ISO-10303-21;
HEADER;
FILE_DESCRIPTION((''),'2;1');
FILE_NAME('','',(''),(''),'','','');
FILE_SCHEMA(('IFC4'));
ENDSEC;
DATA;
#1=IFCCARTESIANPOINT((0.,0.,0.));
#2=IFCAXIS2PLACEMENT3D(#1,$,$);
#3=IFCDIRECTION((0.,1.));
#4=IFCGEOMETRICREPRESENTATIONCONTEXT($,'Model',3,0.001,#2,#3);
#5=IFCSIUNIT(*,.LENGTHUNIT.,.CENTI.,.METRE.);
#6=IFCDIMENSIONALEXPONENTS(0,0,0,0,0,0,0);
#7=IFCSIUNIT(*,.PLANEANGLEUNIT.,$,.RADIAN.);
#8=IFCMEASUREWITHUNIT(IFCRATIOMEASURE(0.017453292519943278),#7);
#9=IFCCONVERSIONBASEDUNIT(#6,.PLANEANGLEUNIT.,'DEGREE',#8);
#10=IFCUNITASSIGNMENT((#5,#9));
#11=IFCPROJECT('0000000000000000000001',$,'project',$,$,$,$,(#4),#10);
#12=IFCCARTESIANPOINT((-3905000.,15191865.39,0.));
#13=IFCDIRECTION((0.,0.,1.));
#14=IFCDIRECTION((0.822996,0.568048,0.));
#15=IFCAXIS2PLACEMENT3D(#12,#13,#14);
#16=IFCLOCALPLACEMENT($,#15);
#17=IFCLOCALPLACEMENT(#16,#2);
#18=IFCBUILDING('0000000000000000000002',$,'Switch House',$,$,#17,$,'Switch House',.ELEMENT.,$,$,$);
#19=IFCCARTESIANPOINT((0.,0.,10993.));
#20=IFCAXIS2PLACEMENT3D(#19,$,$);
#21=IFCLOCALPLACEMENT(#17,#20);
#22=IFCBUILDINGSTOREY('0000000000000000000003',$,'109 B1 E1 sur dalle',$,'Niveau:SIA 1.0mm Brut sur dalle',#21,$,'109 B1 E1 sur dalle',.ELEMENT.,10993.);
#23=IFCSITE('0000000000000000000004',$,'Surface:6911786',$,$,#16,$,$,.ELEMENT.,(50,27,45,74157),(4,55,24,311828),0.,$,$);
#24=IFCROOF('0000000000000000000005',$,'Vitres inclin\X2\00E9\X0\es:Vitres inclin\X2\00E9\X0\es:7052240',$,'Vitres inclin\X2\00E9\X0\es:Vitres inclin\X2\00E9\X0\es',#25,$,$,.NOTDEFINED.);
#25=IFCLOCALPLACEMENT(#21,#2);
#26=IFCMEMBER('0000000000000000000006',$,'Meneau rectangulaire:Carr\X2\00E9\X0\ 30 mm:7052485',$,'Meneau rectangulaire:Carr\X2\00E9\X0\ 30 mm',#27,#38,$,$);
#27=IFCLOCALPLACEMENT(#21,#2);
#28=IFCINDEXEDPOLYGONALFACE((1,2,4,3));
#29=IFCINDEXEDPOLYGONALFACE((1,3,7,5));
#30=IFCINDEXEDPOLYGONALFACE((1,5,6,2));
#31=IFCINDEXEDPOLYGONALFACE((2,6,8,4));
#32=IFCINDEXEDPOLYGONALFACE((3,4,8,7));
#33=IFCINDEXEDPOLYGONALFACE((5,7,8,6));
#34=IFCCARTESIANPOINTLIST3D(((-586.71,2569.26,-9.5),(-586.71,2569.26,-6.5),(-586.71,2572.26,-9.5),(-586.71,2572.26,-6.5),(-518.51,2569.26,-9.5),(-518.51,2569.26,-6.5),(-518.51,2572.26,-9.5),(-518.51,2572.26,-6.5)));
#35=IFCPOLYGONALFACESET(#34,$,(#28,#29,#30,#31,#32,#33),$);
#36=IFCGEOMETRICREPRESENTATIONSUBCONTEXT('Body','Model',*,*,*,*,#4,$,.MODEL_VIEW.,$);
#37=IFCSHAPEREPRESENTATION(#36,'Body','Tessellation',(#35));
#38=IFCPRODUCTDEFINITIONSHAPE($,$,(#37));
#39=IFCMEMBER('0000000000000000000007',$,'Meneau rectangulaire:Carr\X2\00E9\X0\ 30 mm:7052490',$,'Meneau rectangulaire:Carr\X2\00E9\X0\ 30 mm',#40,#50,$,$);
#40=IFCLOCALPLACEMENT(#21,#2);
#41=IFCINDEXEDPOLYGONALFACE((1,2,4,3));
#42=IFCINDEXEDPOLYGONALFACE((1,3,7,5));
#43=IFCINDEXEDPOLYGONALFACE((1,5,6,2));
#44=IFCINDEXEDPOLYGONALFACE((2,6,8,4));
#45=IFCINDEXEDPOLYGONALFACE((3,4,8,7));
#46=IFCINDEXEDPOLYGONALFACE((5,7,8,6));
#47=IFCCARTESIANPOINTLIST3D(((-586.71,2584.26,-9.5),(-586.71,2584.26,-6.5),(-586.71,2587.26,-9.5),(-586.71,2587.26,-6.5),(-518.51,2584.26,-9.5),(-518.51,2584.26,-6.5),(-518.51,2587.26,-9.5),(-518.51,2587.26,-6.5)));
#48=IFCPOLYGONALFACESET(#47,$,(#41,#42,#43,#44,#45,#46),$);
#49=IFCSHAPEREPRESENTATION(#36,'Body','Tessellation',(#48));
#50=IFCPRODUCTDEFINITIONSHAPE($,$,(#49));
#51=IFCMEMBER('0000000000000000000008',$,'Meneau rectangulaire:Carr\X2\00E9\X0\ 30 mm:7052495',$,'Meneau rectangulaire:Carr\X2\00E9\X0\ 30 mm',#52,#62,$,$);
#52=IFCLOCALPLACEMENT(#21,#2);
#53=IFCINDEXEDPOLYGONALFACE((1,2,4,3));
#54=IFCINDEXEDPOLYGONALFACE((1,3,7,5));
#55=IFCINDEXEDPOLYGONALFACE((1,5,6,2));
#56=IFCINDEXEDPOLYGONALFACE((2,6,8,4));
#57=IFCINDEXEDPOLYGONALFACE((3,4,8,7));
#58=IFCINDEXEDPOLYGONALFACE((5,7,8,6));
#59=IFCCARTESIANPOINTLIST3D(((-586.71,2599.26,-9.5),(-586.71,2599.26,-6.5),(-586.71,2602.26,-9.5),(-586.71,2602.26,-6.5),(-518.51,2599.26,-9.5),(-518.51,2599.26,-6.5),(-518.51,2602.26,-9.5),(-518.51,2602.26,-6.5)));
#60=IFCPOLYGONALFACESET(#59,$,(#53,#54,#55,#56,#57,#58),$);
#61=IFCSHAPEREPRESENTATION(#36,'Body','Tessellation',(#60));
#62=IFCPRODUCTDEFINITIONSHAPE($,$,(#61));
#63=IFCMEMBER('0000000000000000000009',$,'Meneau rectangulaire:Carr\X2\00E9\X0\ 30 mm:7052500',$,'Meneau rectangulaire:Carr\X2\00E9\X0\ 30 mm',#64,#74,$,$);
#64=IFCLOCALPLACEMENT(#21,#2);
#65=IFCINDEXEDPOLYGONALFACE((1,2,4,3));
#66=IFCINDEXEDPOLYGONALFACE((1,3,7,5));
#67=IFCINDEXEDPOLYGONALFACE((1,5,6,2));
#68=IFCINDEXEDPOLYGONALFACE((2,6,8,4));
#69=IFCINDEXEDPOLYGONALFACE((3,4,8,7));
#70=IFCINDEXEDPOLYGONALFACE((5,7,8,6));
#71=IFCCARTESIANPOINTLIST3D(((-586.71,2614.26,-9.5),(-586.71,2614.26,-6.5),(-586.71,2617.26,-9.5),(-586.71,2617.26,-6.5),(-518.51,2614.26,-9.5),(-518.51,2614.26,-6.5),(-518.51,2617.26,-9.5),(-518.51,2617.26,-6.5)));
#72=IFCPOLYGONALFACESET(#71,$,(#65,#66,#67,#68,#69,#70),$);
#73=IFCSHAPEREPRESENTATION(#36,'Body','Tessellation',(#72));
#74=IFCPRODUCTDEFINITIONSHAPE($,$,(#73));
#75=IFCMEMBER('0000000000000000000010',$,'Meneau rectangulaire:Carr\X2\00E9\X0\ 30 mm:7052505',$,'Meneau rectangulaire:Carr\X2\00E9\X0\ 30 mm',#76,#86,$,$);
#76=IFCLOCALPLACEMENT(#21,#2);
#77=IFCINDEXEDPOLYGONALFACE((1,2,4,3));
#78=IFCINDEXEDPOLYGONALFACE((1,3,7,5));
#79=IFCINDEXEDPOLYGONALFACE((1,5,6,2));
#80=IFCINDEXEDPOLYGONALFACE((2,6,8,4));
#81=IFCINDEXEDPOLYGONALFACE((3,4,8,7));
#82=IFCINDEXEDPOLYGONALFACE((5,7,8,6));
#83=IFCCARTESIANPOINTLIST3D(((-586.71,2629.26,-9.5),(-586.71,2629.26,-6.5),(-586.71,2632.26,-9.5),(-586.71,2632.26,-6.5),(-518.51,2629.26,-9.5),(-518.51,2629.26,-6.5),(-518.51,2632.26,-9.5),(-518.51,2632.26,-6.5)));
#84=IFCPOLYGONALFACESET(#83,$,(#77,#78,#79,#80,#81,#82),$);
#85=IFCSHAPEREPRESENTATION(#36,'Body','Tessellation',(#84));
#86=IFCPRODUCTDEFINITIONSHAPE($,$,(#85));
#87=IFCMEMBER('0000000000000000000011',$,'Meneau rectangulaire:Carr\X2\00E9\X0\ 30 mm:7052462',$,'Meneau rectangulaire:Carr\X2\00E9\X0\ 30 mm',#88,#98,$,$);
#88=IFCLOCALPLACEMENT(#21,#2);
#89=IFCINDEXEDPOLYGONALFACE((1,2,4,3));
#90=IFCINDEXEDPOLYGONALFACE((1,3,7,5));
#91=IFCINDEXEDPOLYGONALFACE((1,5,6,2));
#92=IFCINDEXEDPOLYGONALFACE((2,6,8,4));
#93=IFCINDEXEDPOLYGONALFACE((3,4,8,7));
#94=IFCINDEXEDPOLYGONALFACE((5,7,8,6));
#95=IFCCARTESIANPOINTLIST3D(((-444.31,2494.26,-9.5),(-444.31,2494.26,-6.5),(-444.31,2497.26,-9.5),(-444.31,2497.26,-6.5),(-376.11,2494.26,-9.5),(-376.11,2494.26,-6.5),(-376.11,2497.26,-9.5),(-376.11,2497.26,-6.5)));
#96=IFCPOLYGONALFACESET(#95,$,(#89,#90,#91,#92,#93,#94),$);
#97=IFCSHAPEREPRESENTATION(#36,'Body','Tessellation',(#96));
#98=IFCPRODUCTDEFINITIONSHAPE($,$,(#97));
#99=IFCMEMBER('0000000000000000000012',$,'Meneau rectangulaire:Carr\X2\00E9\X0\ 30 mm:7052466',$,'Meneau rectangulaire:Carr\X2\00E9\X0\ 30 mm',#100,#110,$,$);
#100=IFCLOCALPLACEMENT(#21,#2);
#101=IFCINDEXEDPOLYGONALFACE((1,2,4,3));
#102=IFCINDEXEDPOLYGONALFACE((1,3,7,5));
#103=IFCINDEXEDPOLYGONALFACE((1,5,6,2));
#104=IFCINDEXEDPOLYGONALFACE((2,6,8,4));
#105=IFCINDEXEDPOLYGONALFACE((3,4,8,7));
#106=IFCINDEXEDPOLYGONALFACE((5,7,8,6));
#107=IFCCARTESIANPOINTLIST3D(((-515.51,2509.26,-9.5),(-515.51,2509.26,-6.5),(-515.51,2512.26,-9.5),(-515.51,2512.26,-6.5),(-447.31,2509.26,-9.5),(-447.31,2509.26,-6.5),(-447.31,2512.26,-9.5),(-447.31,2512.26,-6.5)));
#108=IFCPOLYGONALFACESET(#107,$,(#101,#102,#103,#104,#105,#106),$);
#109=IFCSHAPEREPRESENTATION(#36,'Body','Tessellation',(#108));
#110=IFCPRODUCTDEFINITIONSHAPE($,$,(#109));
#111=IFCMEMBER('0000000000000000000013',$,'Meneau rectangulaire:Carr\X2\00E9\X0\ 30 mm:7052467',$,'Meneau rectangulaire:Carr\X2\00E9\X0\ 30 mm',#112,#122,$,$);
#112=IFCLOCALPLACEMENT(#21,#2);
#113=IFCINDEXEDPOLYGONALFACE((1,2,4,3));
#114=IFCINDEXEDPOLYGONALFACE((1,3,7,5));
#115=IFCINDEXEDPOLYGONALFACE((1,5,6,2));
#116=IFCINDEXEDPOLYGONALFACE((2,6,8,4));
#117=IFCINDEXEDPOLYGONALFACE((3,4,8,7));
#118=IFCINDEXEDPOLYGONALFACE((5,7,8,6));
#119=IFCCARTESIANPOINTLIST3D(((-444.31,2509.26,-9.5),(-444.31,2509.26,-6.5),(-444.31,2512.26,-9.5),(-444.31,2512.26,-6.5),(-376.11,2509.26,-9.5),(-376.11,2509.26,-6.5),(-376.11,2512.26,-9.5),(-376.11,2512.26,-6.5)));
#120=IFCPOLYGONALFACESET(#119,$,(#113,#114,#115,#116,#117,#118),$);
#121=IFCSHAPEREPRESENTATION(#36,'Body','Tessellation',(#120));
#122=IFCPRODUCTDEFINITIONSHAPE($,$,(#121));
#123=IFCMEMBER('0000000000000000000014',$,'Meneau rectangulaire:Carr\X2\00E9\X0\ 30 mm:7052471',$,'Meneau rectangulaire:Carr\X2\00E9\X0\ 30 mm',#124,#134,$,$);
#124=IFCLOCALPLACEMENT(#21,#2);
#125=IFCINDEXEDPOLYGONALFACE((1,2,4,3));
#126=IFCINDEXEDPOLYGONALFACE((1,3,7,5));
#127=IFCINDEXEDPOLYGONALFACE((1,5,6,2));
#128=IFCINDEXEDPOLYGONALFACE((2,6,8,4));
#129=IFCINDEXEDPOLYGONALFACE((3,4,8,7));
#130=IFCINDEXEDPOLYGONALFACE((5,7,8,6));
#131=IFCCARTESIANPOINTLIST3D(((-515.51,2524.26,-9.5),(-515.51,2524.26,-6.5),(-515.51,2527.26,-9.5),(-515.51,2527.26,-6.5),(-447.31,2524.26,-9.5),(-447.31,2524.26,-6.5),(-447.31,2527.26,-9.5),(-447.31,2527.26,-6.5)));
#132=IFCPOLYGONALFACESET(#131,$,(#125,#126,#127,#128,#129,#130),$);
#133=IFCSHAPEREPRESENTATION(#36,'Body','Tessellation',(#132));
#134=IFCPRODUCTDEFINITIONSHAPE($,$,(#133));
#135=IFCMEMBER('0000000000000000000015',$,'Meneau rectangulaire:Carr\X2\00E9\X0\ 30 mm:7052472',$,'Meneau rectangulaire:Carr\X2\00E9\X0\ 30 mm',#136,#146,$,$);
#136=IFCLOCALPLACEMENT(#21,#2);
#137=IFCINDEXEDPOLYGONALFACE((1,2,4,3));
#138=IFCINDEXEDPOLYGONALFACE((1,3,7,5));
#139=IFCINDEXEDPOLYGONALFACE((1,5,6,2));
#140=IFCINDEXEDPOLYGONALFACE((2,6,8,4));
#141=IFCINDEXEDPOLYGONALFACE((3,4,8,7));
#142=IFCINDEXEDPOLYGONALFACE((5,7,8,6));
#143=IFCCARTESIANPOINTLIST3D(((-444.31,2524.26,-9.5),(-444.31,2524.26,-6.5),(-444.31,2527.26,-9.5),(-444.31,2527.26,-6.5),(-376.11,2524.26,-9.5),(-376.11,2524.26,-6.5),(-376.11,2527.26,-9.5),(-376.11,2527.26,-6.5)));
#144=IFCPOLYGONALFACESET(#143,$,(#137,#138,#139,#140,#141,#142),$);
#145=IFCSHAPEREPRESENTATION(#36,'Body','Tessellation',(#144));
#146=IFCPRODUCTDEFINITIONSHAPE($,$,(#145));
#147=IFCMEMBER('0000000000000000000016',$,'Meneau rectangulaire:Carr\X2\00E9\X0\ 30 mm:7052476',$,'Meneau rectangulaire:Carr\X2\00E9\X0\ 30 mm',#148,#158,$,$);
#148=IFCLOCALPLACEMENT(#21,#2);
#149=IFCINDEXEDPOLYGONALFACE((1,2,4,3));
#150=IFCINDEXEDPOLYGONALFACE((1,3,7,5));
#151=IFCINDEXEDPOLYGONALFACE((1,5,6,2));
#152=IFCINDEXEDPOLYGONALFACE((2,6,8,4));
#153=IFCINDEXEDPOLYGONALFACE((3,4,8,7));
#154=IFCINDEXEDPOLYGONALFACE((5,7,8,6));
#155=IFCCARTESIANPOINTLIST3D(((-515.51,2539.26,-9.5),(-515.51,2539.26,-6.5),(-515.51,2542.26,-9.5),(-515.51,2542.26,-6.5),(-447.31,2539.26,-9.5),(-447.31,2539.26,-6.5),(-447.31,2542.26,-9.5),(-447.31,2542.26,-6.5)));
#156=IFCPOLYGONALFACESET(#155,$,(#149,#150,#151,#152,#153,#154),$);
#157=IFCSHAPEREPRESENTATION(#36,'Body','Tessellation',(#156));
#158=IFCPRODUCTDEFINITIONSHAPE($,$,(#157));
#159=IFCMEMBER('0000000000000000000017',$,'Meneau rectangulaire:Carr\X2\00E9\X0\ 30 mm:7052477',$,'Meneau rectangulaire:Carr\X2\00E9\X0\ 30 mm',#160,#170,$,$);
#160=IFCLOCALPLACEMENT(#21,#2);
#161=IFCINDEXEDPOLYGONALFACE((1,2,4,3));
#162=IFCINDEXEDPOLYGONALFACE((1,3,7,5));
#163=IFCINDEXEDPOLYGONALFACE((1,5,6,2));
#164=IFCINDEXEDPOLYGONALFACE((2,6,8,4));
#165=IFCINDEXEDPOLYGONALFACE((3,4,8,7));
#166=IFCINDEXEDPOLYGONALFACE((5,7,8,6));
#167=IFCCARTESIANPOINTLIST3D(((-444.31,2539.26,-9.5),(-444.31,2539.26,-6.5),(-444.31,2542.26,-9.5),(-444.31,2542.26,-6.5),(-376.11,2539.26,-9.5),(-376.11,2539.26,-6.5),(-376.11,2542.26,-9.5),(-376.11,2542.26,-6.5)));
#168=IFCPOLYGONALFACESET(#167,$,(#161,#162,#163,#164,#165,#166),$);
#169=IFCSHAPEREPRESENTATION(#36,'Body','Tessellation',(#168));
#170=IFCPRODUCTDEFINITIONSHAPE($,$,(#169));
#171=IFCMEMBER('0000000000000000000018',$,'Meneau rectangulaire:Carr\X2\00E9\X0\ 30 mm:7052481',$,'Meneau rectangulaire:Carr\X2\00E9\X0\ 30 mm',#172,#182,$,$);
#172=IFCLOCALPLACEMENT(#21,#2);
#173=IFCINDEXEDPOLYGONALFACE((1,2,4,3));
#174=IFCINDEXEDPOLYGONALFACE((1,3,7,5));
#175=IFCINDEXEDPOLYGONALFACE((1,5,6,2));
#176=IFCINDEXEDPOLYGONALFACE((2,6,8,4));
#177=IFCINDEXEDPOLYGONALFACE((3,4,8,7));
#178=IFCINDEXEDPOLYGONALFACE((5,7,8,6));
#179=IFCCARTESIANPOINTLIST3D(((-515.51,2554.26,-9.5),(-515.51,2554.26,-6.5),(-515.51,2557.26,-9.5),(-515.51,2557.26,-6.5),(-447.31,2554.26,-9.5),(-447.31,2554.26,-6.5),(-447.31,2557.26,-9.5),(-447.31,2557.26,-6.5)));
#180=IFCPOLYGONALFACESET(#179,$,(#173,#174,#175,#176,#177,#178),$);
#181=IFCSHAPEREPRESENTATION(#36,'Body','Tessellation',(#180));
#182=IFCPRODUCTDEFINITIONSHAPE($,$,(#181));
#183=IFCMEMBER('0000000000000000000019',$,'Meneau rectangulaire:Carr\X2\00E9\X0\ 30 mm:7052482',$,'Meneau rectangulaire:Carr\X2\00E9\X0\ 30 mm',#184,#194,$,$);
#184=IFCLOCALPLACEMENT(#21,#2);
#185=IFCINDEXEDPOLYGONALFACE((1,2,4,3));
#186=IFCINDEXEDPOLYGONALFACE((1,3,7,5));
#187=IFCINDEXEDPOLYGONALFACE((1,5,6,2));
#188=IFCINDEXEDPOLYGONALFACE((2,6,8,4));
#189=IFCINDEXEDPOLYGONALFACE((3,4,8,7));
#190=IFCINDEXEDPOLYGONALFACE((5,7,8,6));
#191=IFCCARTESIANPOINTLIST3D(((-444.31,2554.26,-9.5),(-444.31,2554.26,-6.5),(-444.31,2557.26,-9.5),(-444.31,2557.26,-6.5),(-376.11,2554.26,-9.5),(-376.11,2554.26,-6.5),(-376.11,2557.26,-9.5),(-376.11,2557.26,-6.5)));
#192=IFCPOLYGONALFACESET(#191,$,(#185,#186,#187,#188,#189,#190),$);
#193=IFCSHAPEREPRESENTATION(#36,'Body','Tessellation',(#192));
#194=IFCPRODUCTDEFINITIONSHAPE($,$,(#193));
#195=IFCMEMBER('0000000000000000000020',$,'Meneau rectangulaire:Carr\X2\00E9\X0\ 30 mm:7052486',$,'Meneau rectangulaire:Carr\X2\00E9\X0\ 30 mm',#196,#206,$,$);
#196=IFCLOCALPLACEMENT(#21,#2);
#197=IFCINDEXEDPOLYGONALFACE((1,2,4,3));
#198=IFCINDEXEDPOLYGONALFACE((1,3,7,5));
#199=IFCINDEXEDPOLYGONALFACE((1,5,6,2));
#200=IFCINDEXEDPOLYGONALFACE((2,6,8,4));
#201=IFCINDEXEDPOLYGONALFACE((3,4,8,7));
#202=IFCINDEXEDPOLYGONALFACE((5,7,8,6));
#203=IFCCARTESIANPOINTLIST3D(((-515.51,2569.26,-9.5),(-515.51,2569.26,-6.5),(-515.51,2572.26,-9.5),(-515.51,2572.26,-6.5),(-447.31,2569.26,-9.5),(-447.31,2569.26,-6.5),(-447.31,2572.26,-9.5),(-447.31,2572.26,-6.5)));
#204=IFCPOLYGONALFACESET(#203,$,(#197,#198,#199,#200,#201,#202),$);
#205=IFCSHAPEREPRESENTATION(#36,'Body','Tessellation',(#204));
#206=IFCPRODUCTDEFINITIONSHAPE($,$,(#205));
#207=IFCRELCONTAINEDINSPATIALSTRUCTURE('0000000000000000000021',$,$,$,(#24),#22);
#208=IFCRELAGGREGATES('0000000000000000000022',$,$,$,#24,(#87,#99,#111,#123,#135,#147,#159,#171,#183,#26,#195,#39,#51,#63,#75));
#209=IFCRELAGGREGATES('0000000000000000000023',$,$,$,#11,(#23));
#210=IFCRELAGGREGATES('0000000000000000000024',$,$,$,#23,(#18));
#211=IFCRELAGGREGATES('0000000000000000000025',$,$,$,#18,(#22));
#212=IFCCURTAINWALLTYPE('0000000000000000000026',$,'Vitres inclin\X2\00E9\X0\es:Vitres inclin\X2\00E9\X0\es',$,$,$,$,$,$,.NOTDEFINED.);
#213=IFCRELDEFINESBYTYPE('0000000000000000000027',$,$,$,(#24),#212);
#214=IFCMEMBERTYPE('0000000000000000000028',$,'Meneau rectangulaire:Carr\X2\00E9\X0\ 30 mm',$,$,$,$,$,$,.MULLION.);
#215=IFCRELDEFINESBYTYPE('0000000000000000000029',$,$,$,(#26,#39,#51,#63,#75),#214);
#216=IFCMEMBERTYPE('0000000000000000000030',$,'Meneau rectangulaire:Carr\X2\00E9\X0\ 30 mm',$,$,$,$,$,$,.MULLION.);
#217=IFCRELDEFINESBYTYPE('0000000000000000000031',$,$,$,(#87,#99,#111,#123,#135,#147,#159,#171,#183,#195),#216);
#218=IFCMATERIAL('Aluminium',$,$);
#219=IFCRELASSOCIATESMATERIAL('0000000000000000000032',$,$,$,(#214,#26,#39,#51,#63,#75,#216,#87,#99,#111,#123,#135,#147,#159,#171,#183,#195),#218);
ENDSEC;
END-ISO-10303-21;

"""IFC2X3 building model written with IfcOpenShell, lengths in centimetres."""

from ifc_helpers import new_model, entity, si_unit, converted_unit, direction, frame, origin, origin_2d_with_axis, place, context, subcontext, project, spatial, rectangle, extrude, source, transform, mapped, material, type_object, type_shapes, element, aggregate, save


model = new_model("IFC2X3")

# Units and contexts
model_context = context("Model", 3, precision=0.001, world=origin(), true_north=direction((0.0, 1.0)))
body_context = subcontext(model_context, "Body", "Model", "MODEL_VIEW")
ifc_project = project(units=[si_unit("LENGTHUNIT", "METRE", prefix="CENTI"), converted_unit("PLANEANGLEUNIT", "DEGREE", entity("IfcRatioMeasure", 0.017453292519943278), si_unit("PLANEANGLEUNIT", "RADIAN"), dimensions=[0, 0, 0, 0, 0, 0, 0])], contexts=[model_context])

# Site, building, storey
site_placement = place(None, frame((-3905000.0, 15191865.39, 0.0), z_axis=(0.0, 0.0, 1.0), x_axis=(0.822996, 0.568048, 0.0)))
site = spatial("IfcSite", under=ifc_project, at=site_placement, Name="Surface:6911786", CompositionType="ELEMENT", RefLatitude=(50, 27, 45, 74157), RefLongitude=(4, 55, 24, 311828), RefElevation=0.0)
building_placement = place(site_placement, origin())
building = spatial("IfcBuilding", under=site, at=building_placement, Name="Switch House", LongName="Switch House", CompositionType="ELEMENT")
storey_placement = place(building_placement, frame((0.0, 0.0, 10993.0)))
storey = spatial("IfcBuildingStorey", under=building, at=storey_placement, Name="109 B1 E1 sur dalle", ObjectType="Niveau:SIA 1.0mm Brut sur dalle", LongName="109 B1 E1 sur dalle", CompositionType="ELEMENT", Elevation=10993.0)

# Roof, members
curtain_wall_type = type_object("IfcCurtainWallType", Name="Vitres inclinées:Vitres inclinées", PredefinedType="NOTDEFINED")
roof_placement = place(storey_placement, frame((0.0, 0.0, -10993.0)))
roof = element("IfcRoof", 1, at=roof_placement, inside=storey, type_object=curtain_wall_type, Name="Vitres inclinées:Vitres inclinées:7052240", ObjectType="Vitres inclinées:Vitres inclinées", ShapeType="NOTDEFINED")
ifc_material = material(Name="Aluminium")
member_type_1 = type_object("IfcMemberType", Name="Meneau rectangulaire:Carré 30 mm", PredefinedType="MULLION", material=ifc_material)
shared_shape_1 = source(origin(), body_context, "Body", "SweptSolid", [
    extrude(rectangle(XDim=3.0, YDim=3.0, at=origin_2d_with_axis()), frame((0.0, 0.0, -68.2), z_axis=(0.0, 0.0, 1.0), x_axis=(0.0, -1.0, 0.0)), (0.0, 0.0, 1.0), 68.2),
])
type_shapes(member_type_1, [shared_shape_1])
member_1_placement = place(roof_placement, frame((-586.71, 2570.76, 10985.0), z_axis=(-1.0, 0.0, 0.0), x_axis=(0.0, 1.0, 0.0)))
member_1 = element("IfcMember", 2, at=member_1_placement, type_object=member_type_1, material=ifc_material, Name="Meneau rectangulaire:Carré 30 mm:7052485", ObjectType="Meneau rectangulaire:Carré 30 mm", context=body_context, shape_type="MappedRepresentation", body=[
    mapped(shared_shape_1, transform((0.0, 0.0, 0.0), scale=1.0)),
])
member_2_placement = place(roof_placement, frame((-586.71, 2585.76, 10985.0), z_axis=(-1.0, 0.0, 0.0), x_axis=(0.0, 1.0, 0.0)))
member_2 = element("IfcMember", 3, at=member_2_placement, type_object=member_type_1, material=ifc_material, Name="Meneau rectangulaire:Carré 30 mm:7052490", ObjectType="Meneau rectangulaire:Carré 30 mm", context=body_context, shape_type="MappedRepresentation", body=[
    mapped(shared_shape_1, transform((0.0, 0.0, 0.0), scale=1.0)),
])
member_3_placement = place(roof_placement, frame((-586.71, 2600.76, 10985.0), z_axis=(-1.0, 0.0, 0.0), x_axis=(0.0, 1.0, 0.0)))
member_3 = element("IfcMember", 4, at=member_3_placement, type_object=member_type_1, material=ifc_material, Name="Meneau rectangulaire:Carré 30 mm:7052495", ObjectType="Meneau rectangulaire:Carré 30 mm", context=body_context, shape_type="MappedRepresentation", body=[
    mapped(shared_shape_1, transform((0.0, 0.0, 0.0), scale=1.0)),
])
member_4_placement = place(roof_placement, frame((-586.71, 2615.76, 10985.0), z_axis=(-1.0, 0.0, 0.0), x_axis=(0.0, 1.0, 0.0)))
member_4 = element("IfcMember", 5, at=member_4_placement, type_object=member_type_1, material=ifc_material, Name="Meneau rectangulaire:Carré 30 mm:7052500", ObjectType="Meneau rectangulaire:Carré 30 mm", context=body_context, shape_type="MappedRepresentation", body=[
    mapped(shared_shape_1, transform((0.0, 0.0, 0.0), scale=1.0)),
])
member_5_placement = place(roof_placement, frame((-586.71, 2630.76, 10985.0), z_axis=(-1.0, 0.0, 0.0), x_axis=(0.0, 1.0, 0.0)))
member_5 = element("IfcMember", 6, at=member_5_placement, type_object=member_type_1, material=ifc_material, Name="Meneau rectangulaire:Carré 30 mm:7052505", ObjectType="Meneau rectangulaire:Carré 30 mm", context=body_context, shape_type="MappedRepresentation", body=[
    mapped(shared_shape_1, transform((0.0, 0.0, 0.0), scale=1.0)),
])
member_type_2 = type_object("IfcMemberType", Name="Meneau rectangulaire:Carré 30 mm", PredefinedType="MULLION", material=ifc_material)
shared_shape_2 = source(origin(), body_context, "Body", "SweptSolid", [
    extrude(rectangle(XDim=3.0, YDim=3.0, at=origin_2d_with_axis()), frame((0.0, 0.0, -68.2), z_axis=(0.0, 0.0, 1.0), x_axis=(0.0, -1.0, 0.0)), (0.0, 0.0, 1.0), 68.2),
])
type_shapes(member_type_2, [shared_shape_2])
member_6_placement = place(roof_placement, frame((-444.31, 2495.76, 10985.0), z_axis=(-1.0, 0.0, 0.0), x_axis=(0.0, 1.0, 0.0)))
member_6 = element("IfcMember", 7, at=member_6_placement, type_object=member_type_2, material=ifc_material, Name="Meneau rectangulaire:Carré 30 mm:7052462", ObjectType="Meneau rectangulaire:Carré 30 mm", context=body_context, shape_type="MappedRepresentation", body=[
    mapped(shared_shape_2, transform((0.0, 0.0, 0.0), scale=1.0)),
])
member_7_placement = place(roof_placement, frame((-515.51, 2510.76, 10985.0), z_axis=(-1.0, 0.0, 0.0), x_axis=(0.0, 1.0, 0.0)))
member_7 = element("IfcMember", 8, at=member_7_placement, type_object=member_type_2, material=ifc_material, Name="Meneau rectangulaire:Carré 30 mm:7052466", ObjectType="Meneau rectangulaire:Carré 30 mm", context=body_context, shape_type="MappedRepresentation", body=[
    mapped(shared_shape_2, transform((0.0, 0.0, 0.0), scale=1.0)),
])
member_8_placement = place(roof_placement, frame((-444.31, 2510.76, 10985.0), z_axis=(-1.0, 0.0, 0.0), x_axis=(0.0, 1.0, 0.0)))
member_8 = element("IfcMember", 9, at=member_8_placement, type_object=member_type_2, material=ifc_material, Name="Meneau rectangulaire:Carré 30 mm:7052467", ObjectType="Meneau rectangulaire:Carré 30 mm", context=body_context, shape_type="MappedRepresentation", body=[
    mapped(shared_shape_2, transform((0.0, 0.0, 0.0), scale=1.0)),
])
member_9_placement = place(roof_placement, frame((-515.51, 2525.76, 10985.0), z_axis=(-1.0, 0.0, 0.0), x_axis=(0.0, 1.0, 0.0)))
member_9 = element("IfcMember", 10, at=member_9_placement, type_object=member_type_2, material=ifc_material, Name="Meneau rectangulaire:Carré 30 mm:7052471", ObjectType="Meneau rectangulaire:Carré 30 mm", context=body_context, shape_type="MappedRepresentation", body=[
    mapped(shared_shape_2, transform((0.0, 0.0, 0.0), scale=1.0)),
])
member_10_placement = place(roof_placement, frame((-444.31, 2525.76, 10985.0), z_axis=(-1.0, 0.0, 0.0), x_axis=(0.0, 1.0, 0.0)))
member_10 = element("IfcMember", 11, at=member_10_placement, type_object=member_type_2, material=ifc_material, Name="Meneau rectangulaire:Carré 30 mm:7052472", ObjectType="Meneau rectangulaire:Carré 30 mm", context=body_context, shape_type="MappedRepresentation", body=[
    mapped(shared_shape_2, transform((0.0, 0.0, 0.0), scale=1.0)),
])
member_11_placement = place(roof_placement, frame((-515.51, 2540.76, 10985.0), z_axis=(-1.0, 0.0, 0.0), x_axis=(0.0, 1.0, 0.0)))
member_11 = element("IfcMember", 12, at=member_11_placement, type_object=member_type_2, material=ifc_material, Name="Meneau rectangulaire:Carré 30 mm:7052476", ObjectType="Meneau rectangulaire:Carré 30 mm", context=body_context, shape_type="MappedRepresentation", body=[
    mapped(shared_shape_2, transform((0.0, 0.0, 0.0), scale=1.0)),
])
member_12_placement = place(roof_placement, frame((-444.31, 2540.76, 10985.0), z_axis=(-1.0, 0.0, 0.0), x_axis=(0.0, 1.0, 0.0)))
member_12 = element("IfcMember", 13, at=member_12_placement, type_object=member_type_2, material=ifc_material, Name="Meneau rectangulaire:Carré 30 mm:7052477", ObjectType="Meneau rectangulaire:Carré 30 mm", context=body_context, shape_type="MappedRepresentation", body=[
    mapped(shared_shape_2, transform((0.0, 0.0, 0.0), scale=1.0)),
])
member_13_placement = place(roof_placement, frame((-515.51, 2555.76, 10985.0), z_axis=(-1.0, 0.0, 0.0), x_axis=(0.0, 1.0, 0.0)))
member_13 = element("IfcMember", 14, at=member_13_placement, type_object=member_type_2, material=ifc_material, Name="Meneau rectangulaire:Carré 30 mm:7052481", ObjectType="Meneau rectangulaire:Carré 30 mm", context=body_context, shape_type="MappedRepresentation", body=[
    mapped(shared_shape_2, transform((0.0, 0.0, 0.0), scale=1.0)),
])
member_14_placement = place(roof_placement, frame((-444.31, 2555.76, 10985.0), z_axis=(-1.0, 0.0, 0.0), x_axis=(0.0, 1.0, 0.0)))
member_14 = element("IfcMember", 15, at=member_14_placement, type_object=member_type_2, material=ifc_material, Name="Meneau rectangulaire:Carré 30 mm:7052482", ObjectType="Meneau rectangulaire:Carré 30 mm", context=body_context, shape_type="MappedRepresentation", body=[
    mapped(shared_shape_2, transform((0.0, 0.0, 0.0), scale=1.0)),
])
member_15_placement = place(roof_placement, frame((-515.51, 2570.76, 10985.0), z_axis=(-1.0, 0.0, 0.0), x_axis=(0.0, 1.0, 0.0)))
member_15 = element("IfcMember", 16, at=member_15_placement, type_object=member_type_2, material=ifc_material, Name="Meneau rectangulaire:Carré 30 mm:7052486", ObjectType="Meneau rectangulaire:Carré 30 mm", context=body_context, shape_type="MappedRepresentation", body=[
    mapped(shared_shape_2, transform((0.0, 0.0, 0.0), scale=1.0)),
])
aggregate(roof, [member_6, member_7, member_8, member_9, member_10, member_11, member_12, member_13, member_14, member_1, member_15, member_2, member_3, member_4, member_5])

save(model, "model.ifc")
